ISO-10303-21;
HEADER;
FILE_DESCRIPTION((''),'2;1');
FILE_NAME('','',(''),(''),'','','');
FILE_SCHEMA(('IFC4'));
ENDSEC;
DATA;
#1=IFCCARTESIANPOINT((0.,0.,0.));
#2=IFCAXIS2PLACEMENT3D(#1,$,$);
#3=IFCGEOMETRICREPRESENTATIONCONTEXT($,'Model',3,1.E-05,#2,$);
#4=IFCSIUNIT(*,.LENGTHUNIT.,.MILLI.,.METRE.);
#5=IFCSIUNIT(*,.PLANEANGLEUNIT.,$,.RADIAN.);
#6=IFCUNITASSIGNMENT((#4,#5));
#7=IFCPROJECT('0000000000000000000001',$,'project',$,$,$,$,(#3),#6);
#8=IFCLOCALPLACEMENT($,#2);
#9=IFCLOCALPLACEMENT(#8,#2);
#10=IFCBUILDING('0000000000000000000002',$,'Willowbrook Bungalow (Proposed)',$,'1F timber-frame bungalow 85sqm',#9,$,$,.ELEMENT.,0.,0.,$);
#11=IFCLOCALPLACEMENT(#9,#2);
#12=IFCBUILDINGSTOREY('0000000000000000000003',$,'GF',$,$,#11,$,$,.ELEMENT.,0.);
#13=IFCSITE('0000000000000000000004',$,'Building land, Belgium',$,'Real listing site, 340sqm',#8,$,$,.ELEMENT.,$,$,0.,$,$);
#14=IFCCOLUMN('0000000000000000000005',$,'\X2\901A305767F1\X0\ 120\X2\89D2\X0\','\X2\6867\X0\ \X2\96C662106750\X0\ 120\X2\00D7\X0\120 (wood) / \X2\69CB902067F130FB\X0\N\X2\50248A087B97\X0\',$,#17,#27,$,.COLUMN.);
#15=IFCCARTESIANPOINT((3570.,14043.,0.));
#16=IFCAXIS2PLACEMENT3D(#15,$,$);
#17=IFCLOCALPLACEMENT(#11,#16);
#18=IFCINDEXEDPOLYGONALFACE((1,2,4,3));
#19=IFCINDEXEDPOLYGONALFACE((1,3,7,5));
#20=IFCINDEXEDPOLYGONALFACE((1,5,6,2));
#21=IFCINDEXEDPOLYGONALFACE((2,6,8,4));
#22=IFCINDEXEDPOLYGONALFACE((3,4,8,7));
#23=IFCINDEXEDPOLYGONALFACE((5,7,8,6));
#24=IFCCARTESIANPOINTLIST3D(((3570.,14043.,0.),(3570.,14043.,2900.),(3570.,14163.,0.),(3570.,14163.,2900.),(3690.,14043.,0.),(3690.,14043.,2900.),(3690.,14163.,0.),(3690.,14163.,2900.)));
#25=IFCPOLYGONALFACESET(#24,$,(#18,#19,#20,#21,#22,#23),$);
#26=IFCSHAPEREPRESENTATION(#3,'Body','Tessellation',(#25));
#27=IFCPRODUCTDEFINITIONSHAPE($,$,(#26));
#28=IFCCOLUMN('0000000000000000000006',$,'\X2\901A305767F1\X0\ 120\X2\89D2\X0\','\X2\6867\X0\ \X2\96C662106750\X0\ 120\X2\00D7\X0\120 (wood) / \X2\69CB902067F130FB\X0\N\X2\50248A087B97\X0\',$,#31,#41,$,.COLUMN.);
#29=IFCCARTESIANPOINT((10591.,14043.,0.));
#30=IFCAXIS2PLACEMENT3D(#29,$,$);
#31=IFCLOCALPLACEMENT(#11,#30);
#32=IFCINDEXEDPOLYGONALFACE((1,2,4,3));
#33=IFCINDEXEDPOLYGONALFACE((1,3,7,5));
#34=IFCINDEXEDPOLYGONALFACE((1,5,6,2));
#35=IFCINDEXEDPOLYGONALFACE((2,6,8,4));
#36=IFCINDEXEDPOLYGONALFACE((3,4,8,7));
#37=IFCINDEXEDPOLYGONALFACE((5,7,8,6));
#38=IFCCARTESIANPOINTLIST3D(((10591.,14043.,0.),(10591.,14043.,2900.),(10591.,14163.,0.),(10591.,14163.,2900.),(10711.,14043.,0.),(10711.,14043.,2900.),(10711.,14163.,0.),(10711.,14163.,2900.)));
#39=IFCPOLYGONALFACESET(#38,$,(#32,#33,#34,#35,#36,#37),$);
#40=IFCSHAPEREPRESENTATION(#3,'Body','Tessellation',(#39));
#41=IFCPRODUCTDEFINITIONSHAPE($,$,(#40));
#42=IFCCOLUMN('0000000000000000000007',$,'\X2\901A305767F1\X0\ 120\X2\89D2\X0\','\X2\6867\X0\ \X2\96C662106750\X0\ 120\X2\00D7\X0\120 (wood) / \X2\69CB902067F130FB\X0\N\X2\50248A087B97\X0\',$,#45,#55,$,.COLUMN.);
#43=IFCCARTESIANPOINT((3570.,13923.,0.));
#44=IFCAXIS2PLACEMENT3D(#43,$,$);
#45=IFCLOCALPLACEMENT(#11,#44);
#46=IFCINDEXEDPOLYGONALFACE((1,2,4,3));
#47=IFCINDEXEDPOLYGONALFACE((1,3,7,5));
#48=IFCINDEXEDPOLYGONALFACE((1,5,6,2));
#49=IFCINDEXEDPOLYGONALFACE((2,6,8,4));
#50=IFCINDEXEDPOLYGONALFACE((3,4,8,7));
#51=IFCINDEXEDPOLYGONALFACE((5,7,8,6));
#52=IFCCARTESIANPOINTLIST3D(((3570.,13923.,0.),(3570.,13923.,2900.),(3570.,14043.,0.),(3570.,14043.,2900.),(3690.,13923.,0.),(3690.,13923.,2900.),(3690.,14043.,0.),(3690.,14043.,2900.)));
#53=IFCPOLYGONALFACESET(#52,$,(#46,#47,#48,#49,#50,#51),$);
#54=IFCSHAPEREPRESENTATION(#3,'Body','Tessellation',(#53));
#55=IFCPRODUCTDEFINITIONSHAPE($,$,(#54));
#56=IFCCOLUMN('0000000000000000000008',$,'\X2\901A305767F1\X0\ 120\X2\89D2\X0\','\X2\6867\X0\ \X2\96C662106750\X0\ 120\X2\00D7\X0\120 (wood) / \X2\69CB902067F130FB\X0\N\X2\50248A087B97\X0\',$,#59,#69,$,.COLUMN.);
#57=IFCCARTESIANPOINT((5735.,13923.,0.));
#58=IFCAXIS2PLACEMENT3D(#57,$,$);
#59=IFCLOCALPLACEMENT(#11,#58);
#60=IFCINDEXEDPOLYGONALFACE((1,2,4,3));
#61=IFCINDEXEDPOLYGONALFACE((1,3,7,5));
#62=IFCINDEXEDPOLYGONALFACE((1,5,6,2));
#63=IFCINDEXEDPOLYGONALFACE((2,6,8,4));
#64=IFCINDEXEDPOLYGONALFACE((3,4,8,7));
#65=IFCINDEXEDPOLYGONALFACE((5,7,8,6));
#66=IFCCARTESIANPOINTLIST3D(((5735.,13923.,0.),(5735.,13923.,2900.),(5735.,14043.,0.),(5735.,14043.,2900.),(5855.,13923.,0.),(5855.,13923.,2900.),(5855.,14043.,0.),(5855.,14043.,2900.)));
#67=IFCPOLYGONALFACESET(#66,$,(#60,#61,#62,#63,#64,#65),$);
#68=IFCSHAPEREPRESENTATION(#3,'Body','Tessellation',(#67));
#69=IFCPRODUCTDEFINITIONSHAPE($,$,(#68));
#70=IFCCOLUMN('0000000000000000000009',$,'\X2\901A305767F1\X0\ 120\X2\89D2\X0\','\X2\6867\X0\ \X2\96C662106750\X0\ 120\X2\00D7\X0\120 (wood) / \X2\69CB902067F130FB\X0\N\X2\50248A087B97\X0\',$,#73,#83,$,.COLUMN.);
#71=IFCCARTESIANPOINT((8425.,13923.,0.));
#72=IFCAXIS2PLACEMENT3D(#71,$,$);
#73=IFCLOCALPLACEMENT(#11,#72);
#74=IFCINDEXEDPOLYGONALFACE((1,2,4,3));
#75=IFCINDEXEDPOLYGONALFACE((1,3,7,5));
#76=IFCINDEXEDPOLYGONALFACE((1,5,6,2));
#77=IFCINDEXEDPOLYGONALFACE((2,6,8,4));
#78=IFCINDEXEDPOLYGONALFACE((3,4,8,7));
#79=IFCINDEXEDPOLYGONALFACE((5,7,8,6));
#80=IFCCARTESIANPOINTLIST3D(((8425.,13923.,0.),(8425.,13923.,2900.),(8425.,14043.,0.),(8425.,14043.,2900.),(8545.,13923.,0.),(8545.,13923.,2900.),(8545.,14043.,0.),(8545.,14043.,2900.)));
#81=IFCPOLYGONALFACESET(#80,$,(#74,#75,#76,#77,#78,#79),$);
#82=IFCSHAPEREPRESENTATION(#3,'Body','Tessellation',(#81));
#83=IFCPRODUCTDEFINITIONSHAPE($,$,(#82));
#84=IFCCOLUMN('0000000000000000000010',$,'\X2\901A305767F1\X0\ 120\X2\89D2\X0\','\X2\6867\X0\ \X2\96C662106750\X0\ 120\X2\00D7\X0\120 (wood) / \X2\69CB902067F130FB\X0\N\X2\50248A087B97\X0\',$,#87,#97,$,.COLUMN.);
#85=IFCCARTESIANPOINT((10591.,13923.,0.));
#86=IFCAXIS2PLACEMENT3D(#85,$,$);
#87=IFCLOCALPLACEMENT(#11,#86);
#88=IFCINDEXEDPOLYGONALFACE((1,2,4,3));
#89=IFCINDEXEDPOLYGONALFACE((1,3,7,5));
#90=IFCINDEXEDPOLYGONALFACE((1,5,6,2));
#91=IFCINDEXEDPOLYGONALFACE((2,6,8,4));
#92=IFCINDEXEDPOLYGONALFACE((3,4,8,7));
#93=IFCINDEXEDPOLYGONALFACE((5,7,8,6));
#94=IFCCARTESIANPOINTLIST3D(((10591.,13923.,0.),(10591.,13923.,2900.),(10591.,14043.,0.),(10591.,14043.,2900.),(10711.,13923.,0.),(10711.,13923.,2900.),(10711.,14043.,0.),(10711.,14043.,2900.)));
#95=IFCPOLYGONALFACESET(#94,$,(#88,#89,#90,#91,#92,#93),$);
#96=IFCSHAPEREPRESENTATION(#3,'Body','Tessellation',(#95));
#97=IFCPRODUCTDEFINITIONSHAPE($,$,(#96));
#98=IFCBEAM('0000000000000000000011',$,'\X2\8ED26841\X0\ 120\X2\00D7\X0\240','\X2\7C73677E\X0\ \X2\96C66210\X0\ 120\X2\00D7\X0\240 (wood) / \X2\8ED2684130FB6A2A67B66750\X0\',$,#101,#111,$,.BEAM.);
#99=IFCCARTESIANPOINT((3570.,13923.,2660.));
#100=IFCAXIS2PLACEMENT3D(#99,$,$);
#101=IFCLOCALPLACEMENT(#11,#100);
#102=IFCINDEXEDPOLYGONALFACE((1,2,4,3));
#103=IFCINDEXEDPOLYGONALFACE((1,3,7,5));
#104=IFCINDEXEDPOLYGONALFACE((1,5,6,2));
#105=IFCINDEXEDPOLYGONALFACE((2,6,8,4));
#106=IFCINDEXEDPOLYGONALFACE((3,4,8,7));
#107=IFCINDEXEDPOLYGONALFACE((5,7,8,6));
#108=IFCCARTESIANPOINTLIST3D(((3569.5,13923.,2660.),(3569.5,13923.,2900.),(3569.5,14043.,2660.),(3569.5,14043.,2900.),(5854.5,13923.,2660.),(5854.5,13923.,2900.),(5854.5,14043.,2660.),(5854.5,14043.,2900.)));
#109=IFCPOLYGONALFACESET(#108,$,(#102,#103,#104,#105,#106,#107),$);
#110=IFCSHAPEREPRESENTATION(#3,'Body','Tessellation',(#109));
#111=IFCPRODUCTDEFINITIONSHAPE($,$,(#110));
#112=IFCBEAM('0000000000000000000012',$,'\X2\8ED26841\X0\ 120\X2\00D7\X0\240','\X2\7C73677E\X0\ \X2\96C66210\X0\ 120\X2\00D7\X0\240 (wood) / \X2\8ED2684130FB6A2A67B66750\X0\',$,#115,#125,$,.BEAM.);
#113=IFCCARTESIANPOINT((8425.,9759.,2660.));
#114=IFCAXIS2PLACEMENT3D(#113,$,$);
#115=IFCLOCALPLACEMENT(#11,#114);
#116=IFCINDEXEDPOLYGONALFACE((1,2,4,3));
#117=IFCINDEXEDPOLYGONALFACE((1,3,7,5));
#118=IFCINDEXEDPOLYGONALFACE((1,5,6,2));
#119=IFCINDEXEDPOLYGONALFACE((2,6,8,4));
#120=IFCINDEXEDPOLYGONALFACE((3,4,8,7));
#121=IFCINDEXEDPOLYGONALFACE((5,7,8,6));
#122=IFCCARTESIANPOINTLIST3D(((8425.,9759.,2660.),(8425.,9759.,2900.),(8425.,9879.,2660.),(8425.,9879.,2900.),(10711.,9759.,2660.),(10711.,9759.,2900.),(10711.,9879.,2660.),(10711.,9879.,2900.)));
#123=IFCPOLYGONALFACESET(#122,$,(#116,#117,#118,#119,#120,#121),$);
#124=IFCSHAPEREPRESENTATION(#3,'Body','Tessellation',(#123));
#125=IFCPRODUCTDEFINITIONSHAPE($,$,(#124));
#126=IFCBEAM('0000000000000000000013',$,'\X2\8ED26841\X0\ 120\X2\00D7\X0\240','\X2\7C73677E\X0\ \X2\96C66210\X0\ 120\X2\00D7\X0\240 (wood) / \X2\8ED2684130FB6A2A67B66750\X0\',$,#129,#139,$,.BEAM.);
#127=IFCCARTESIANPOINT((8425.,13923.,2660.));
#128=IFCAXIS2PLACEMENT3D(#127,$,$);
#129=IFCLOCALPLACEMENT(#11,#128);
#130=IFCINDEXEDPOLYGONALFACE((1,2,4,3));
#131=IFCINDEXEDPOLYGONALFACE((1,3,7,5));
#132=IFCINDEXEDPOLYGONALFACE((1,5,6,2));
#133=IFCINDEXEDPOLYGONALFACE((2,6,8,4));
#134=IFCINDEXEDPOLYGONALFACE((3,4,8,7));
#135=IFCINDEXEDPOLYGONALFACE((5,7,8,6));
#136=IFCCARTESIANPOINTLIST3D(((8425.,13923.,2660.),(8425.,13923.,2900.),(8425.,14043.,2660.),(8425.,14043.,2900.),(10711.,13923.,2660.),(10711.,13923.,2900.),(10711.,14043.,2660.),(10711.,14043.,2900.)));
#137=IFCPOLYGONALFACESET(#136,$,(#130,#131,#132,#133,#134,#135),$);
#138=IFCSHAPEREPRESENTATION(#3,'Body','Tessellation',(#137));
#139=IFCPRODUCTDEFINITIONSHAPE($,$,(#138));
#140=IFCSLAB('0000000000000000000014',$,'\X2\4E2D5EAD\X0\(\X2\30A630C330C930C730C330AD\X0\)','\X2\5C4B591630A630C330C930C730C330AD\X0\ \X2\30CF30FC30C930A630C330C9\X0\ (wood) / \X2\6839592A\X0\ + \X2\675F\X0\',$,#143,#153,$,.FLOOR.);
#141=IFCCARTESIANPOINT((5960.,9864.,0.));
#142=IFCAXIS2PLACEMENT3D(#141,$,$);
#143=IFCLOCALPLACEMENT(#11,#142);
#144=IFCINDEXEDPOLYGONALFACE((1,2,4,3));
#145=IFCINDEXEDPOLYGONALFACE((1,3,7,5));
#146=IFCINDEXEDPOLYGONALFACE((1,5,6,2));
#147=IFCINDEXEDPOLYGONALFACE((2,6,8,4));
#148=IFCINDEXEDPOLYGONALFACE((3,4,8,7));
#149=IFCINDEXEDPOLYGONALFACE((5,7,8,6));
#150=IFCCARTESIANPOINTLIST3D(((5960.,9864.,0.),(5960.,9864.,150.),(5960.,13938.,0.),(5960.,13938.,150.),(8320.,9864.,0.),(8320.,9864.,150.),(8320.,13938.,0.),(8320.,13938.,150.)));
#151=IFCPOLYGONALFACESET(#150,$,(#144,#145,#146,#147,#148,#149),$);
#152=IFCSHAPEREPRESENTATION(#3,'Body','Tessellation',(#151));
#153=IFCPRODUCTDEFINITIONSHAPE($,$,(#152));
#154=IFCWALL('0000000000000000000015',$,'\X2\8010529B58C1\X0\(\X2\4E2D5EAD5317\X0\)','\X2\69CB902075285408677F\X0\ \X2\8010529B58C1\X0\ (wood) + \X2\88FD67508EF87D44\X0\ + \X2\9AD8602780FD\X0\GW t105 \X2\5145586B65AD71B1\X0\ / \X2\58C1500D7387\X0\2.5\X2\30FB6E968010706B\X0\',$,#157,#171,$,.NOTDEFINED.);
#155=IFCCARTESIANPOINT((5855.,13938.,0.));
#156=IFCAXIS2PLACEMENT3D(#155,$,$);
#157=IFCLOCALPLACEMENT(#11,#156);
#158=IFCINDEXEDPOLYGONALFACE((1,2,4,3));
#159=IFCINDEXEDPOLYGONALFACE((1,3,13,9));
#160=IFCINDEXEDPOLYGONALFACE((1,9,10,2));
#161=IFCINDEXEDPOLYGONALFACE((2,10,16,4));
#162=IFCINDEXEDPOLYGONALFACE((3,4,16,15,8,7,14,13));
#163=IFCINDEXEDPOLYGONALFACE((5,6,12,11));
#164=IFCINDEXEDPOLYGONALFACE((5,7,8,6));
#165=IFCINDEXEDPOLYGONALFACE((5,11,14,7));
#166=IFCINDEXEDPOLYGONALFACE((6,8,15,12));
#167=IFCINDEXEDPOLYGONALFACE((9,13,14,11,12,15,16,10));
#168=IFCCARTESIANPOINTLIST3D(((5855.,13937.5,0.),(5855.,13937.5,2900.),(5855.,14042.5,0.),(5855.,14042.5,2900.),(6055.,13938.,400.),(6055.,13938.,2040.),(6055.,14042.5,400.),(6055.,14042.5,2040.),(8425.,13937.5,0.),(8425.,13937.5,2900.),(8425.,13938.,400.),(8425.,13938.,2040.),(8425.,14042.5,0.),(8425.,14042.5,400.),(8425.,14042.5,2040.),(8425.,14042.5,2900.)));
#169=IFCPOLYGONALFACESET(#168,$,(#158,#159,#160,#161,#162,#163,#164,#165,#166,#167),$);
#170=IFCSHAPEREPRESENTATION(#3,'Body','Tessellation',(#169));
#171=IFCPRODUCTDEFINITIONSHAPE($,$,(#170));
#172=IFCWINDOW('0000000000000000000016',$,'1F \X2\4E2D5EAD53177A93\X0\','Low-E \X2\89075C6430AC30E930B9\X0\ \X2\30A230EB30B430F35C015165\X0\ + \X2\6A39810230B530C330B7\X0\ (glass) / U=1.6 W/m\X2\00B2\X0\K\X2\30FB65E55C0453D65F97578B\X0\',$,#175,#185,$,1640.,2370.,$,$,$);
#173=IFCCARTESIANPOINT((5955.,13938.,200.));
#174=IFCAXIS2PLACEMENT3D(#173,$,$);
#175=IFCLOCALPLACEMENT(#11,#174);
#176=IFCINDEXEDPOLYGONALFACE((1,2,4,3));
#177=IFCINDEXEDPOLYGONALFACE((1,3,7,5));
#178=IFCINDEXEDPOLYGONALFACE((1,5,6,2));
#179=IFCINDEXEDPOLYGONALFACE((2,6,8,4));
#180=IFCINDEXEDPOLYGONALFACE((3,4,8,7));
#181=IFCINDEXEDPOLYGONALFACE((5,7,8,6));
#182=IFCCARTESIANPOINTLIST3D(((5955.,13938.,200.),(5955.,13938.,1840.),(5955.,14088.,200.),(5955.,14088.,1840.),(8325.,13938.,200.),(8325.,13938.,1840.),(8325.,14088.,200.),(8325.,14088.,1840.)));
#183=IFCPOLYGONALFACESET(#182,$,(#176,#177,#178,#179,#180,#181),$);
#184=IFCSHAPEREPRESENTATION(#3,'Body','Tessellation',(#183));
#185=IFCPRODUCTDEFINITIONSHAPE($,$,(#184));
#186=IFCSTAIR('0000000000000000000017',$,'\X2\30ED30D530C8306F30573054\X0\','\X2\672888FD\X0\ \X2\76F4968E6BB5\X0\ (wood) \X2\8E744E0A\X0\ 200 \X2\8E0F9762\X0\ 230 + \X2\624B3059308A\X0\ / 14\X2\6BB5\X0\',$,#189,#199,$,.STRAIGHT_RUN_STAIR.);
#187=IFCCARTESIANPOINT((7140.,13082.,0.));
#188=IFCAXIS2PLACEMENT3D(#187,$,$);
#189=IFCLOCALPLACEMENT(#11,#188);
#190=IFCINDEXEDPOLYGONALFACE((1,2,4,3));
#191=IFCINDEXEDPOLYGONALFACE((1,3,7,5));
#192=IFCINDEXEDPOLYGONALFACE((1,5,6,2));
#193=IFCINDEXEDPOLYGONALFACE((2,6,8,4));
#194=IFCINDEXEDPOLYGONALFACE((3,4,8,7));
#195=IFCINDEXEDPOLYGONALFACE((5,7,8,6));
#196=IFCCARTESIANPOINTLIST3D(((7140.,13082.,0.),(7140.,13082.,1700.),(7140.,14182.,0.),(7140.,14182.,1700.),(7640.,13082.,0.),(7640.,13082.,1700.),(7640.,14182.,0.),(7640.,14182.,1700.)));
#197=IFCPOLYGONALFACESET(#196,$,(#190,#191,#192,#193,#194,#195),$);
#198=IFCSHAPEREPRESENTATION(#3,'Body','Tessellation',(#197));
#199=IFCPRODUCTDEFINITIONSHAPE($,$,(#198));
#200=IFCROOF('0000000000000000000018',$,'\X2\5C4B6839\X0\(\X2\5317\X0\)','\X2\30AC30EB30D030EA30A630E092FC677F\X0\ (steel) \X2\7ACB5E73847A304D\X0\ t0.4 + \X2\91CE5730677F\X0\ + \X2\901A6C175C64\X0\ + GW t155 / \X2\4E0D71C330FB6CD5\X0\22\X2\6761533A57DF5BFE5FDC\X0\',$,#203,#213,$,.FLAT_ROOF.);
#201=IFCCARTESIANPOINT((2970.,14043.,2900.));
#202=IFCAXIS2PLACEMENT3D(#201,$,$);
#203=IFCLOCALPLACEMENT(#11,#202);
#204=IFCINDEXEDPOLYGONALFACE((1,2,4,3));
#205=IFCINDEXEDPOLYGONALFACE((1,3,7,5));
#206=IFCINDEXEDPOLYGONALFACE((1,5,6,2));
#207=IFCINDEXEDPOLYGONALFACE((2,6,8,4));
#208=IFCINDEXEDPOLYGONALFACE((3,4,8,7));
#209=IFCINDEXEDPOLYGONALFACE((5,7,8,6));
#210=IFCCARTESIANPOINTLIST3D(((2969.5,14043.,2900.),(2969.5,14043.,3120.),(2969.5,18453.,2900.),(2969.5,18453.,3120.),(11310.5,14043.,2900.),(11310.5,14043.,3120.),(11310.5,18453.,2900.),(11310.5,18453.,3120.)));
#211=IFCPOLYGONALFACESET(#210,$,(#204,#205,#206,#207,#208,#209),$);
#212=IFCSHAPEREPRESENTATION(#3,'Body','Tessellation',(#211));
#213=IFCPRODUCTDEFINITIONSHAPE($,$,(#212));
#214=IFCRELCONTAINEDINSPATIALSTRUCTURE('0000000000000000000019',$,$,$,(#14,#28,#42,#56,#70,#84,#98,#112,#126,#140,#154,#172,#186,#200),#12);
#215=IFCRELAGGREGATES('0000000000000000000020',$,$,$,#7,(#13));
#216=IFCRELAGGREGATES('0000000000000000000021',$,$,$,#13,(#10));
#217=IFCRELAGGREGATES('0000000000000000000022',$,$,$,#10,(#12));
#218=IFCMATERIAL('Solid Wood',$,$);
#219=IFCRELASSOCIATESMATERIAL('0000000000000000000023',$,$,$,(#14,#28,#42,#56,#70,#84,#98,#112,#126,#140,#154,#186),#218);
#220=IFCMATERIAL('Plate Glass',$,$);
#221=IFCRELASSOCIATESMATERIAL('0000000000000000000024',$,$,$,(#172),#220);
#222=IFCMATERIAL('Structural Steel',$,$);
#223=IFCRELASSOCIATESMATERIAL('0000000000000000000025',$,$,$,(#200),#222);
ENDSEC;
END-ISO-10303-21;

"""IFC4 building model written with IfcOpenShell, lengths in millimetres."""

from ifc_helpers import new_model, si_unit, frame, frame_2d, origin, place, context, project, spatial, rectangle, extrude, material, element, fill, save


model = new_model("IFC4")

# Units and contexts
model_context = context("Model", 3, precision=1e-05, world=origin())
ifc_project = project(units=[si_unit("LENGTHUNIT", "METRE", prefix="MILLI"), si_unit("PLANEANGLEUNIT", "RADIAN")], contexts=[model_context])

# Site, building, storey
site_placement = place(None, origin())
site = spatial("IfcSite", under=ifc_project, at=site_placement, Name="Building land, Belgium", ObjectType="Real listing site, 340sqm", CompositionType="ELEMENT", RefElevation=0.0)
building_placement = place(site_placement, origin())
building = spatial("IfcBuilding", under=site, at=building_placement, Name="Willowbrook Bungalow (Proposed)", ObjectType="1F timber-frame bungalow 85sqm", CompositionType="ELEMENT", ElevationOfRefHeight=0.0, ElevationOfTerrain=0.0)
storey_placement = place(building_placement, origin())
storey = spatial("IfcBuildingStorey", under=building, at=storey_placement, Name="GF", CompositionType="ELEMENT", Elevation=0.0)

# Columns
ifc_material_1 = material(Name="Solid Wood")
column_1_placement = place(storey_placement, frame((3570.0, 14043.0, 0.0)))
element("IfcColumn", 1, at=column_1_placement, inside=storey, material=ifc_material_1, Name="通し柱 120角", Description="桧 集成材 120×120 (wood) / 構造柱・N値計算", PredefinedType="COLUMN", context=model_context, shape_type="SweptSolid", body=[
    extrude(rectangle(XDim=120.0, YDim=120.0, at=frame_2d((60.0, 60.0))), frame((3570.0, 14043.0, 0.0)), (0.0, 0.0, 1.0), 2900.0),
])
column_2_placement = place(storey_placement, frame((10591.0, 14043.0, 0.0)))
element("IfcColumn", 2, at=column_2_placement, inside=storey, material=ifc_material_1, Name="通し柱 120角", Description="桧 集成材 120×120 (wood) / 構造柱・N値計算", PredefinedType="COLUMN", context=model_context, shape_type="SweptSolid", body=[
    extrude(rectangle(XDim=120.0, YDim=120.0, at=frame_2d((60.0, 60.0))), frame((10591.0, 14043.0, 0.0)), (0.0, 0.0, 1.0), 2900.0),
])
column_3_placement = place(storey_placement, frame((3570.0, 13923.0, 0.0)))
element("IfcColumn", 3, at=column_3_placement, inside=storey, material=ifc_material_1, Name="通し柱 120角", Description="桧 集成材 120×120 (wood) / 構造柱・N値計算", PredefinedType="COLUMN", context=model_context, shape_type="SweptSolid", body=[
    extrude(rectangle(XDim=120.0, YDim=120.0, at=frame_2d((60.0, 60.0))), frame((3570.0, 13923.0, 0.0)), (0.0, 0.0, 1.0), 2900.0),
])
column_4_placement = place(storey_placement, frame((5735.0, 13923.0, 0.0)))
element("IfcColumn", 4, at=column_4_placement, inside=storey, material=ifc_material_1, Name="通し柱 120角", Description="桧 集成材 120×120 (wood) / 構造柱・N値計算", PredefinedType="COLUMN", context=model_context, shape_type="SweptSolid", body=[
    extrude(rectangle(XDim=120.0, YDim=120.0, at=frame_2d((60.0, 60.0))), frame((5735.0, 13923.0, 0.0)), (0.0, 0.0, 1.0), 2900.0),
])
column_5_placement = place(storey_placement, frame((8425.0, 13923.0, 0.0)))
element("IfcColumn", 5, at=column_5_placement, inside=storey, material=ifc_material_1, Name="通し柱 120角", Description="桧 集成材 120×120 (wood) / 構造柱・N値計算", PredefinedType="COLUMN", context=model_context, shape_type="SweptSolid", body=[
    extrude(rectangle(XDim=120.0, YDim=120.0, at=frame_2d((60.0, 60.0))), frame((8425.0, 13923.0, 0.0)), (0.0, 0.0, 1.0), 2900.0),
])
column_6_placement = place(storey_placement, frame((10591.0, 13923.0, 0.0)))
element("IfcColumn", 6, at=column_6_placement, inside=storey, material=ifc_material_1, Name="通し柱 120角", Description="桧 集成材 120×120 (wood) / 構造柱・N値計算", PredefinedType="COLUMN", context=model_context, shape_type="SweptSolid", body=[
    extrude(rectangle(XDim=120.0, YDim=120.0, at=frame_2d((60.0, 60.0))), frame((10591.0, 13923.0, 0.0)), (0.0, 0.0, 1.0), 2900.0),
])

# Beams
beam_1_placement = place(storey_placement, frame((3570.0, 13923.0, 2660.0)))
element("IfcBeam", 7, at=beam_1_placement, inside=storey, material=ifc_material_1, Name="軒桁 120×240", Description="米松 集成 120×240 (wood) / 軒桁・横架材", PredefinedType="BEAM", context=model_context, shape_type="SweptSolid", body=[
    extrude(rectangle(XDim=2285.0, YDim=120.0, at=frame_2d((1142.0, 60.0))), frame((3570.0, 13923.0, 2660.0)), (0.0, 0.0, 1.0), 240.0),
])
beam_2_placement = place(storey_placement, frame((8425.0, 9759.0, 2660.0)))
element("IfcBeam", 8, at=beam_2_placement, inside=storey, material=ifc_material_1, Name="軒桁 120×240", Description="米松 集成 120×240 (wood) / 軒桁・横架材", PredefinedType="BEAM", context=model_context, shape_type="SweptSolid", body=[
    extrude(rectangle(XDim=2286.0, YDim=120.0, at=frame_2d((1143.0, 60.0))), frame((8425.0, 9759.0, 2660.0)), (0.0, 0.0, 1.0), 240.0),
])
beam_3_placement = place(storey_placement, frame((8425.0, 13923.0, 2660.0)))
element("IfcBeam", 9, at=beam_3_placement, inside=storey, material=ifc_material_1, Name="軒桁 120×240", Description="米松 集成 120×240 (wood) / 軒桁・横架材", PredefinedType="BEAM", context=model_context, shape_type="SweptSolid", body=[
    extrude(rectangle(XDim=2286.0, YDim=120.0, at=frame_2d((1143.0, 60.0))), frame((8425.0, 13923.0, 2660.0)), (0.0, 0.0, 1.0), 240.0),
])

# Slab
slab_1_placement = place(storey_placement, frame((5960.0, 9864.0, 0.0)))
element("IfcSlab", 10, at=slab_1_placement, inside=storey, material=ifc_material_1, Name="中庭(ウッドデッキ)", Description="屋外ウッドデッキ ハードウッド (wood) / 根太 + 束", PredefinedType="FLOOR", context=model_context, shape_type="SweptSolid", body=[
    extrude(rectangle(XDim=2360.0, YDim=4074.0, at=frame_2d((1180.0, 2037.0))), frame((5960.0, 9864.0, 0.0)), (0.0, 0.0, 1.0), 150.0),
])

# Wall, opening, window
wall_placement = place(storey_placement, frame((5855.0, 13938.0, 0.0)))
wall = element("IfcWall", 11, at=wall_placement, inside=storey, material=ifc_material_1, Name="耐力壁(中庭北)", Description="構造用合板 耐力壁 (wood) + 製材軸組 + 高性能GW t105 充填断熱 / 壁倍率2.5・準耐火", PredefinedType="NOTDEFINED", context=model_context, shape_type="SweptSolid", body=[
    extrude(rectangle(XDim=2570.0, YDim=105.0, at=frame_2d((1285.0, 52.0))), frame((5855.0, 13938.0, 0.0)), (0.0, 0.0, 1.0), 2900.0),
])
opening_placement = place(storey_placement, frame((5955.0, 13938.0, 200.0)))
opening = element("IfcOpeningElement", 12, at=opening_placement, cuts=wall, PredefinedType="NOTDEFINED", context=model_context, shape_type="SweptSolid", body=[
    extrude(rectangle(XDim=2370.0, YDim=150.0, at=frame_2d((1185.0, 75.0))), frame((5955.0, 13938.0, 200.0)), (0.0, 0.0, 1.0), 1640.0),
])
ifc_material_2 = material(Name="Plate Glass")
window_placement = place(storey_placement, frame((5955.0, 13938.0, 200.0)))
window = element("IfcWindow", 13, at=window_placement, inside=storey, material=ifc_material_2, Name="1F 中庭北窓", Description="Low-E 複層ガラス アルゴン封入 + 樹脂サッシ (glass) / U=1.6 W/m²K・日射取得型", OverallHeight=1640.0, OverallWidth=2370.0, context=model_context, shape_type="SweptSolid", body=[
    extrude(rectangle(XDim=2370.0, YDim=150.0, at=frame_2d((1185.0, 75.0))), frame((5955.0, 13938.0, 200.0)), (0.0, 0.0, 1.0), 1640.0),
])
fill(opening, window)

# Stair
stair_placement = place(storey_placement, frame((7140.0, 13082.0, 0.0)))
element("IfcStair", 14, at=stair_placement, inside=storey, material=ifc_material_1, Name="ロフトはしご", Description="木製 直階段 (wood) 蹴上 200 踏面 230 + 手すり / 14段", PredefinedType="STRAIGHT_RUN_STAIR", context=model_context, shape_type="SweptSolid", body=[
    extrude(rectangle(XDim=500.0, YDim=1100.0, at=frame_2d((250.0, 550.0))), frame((7140.0, 13082.0, 0.0)), (0.0, 0.0, 1.0), 1700.0),
])

# Roof
ifc_material_3 = material(Name="Structural Steel")
roof_placement = place(storey_placement, frame((2970.0, 14043.0, 2900.0)))
element("IfcRoof", 15, at=roof_placement, inside=storey, material=ifc_material_3, Name="屋根(北)", Description="ガルバリウム鋼板 (steel) 立平葺き t0.4 + 野地板 + 通気層 + GW t155 / 不燃・法22条区域対応", PredefinedType="FLAT_ROOF", context=model_context, shape_type="SweptSolid", body=[
    extrude(rectangle(XDim=8341.0, YDim=4410.0, at=frame_2d((4170.0, 2205.0))), frame((2970.0, 14043.0, 2900.0)), (0.0, 0.0, 1.0), 220.0),
])

save(model, "model.ifc")
